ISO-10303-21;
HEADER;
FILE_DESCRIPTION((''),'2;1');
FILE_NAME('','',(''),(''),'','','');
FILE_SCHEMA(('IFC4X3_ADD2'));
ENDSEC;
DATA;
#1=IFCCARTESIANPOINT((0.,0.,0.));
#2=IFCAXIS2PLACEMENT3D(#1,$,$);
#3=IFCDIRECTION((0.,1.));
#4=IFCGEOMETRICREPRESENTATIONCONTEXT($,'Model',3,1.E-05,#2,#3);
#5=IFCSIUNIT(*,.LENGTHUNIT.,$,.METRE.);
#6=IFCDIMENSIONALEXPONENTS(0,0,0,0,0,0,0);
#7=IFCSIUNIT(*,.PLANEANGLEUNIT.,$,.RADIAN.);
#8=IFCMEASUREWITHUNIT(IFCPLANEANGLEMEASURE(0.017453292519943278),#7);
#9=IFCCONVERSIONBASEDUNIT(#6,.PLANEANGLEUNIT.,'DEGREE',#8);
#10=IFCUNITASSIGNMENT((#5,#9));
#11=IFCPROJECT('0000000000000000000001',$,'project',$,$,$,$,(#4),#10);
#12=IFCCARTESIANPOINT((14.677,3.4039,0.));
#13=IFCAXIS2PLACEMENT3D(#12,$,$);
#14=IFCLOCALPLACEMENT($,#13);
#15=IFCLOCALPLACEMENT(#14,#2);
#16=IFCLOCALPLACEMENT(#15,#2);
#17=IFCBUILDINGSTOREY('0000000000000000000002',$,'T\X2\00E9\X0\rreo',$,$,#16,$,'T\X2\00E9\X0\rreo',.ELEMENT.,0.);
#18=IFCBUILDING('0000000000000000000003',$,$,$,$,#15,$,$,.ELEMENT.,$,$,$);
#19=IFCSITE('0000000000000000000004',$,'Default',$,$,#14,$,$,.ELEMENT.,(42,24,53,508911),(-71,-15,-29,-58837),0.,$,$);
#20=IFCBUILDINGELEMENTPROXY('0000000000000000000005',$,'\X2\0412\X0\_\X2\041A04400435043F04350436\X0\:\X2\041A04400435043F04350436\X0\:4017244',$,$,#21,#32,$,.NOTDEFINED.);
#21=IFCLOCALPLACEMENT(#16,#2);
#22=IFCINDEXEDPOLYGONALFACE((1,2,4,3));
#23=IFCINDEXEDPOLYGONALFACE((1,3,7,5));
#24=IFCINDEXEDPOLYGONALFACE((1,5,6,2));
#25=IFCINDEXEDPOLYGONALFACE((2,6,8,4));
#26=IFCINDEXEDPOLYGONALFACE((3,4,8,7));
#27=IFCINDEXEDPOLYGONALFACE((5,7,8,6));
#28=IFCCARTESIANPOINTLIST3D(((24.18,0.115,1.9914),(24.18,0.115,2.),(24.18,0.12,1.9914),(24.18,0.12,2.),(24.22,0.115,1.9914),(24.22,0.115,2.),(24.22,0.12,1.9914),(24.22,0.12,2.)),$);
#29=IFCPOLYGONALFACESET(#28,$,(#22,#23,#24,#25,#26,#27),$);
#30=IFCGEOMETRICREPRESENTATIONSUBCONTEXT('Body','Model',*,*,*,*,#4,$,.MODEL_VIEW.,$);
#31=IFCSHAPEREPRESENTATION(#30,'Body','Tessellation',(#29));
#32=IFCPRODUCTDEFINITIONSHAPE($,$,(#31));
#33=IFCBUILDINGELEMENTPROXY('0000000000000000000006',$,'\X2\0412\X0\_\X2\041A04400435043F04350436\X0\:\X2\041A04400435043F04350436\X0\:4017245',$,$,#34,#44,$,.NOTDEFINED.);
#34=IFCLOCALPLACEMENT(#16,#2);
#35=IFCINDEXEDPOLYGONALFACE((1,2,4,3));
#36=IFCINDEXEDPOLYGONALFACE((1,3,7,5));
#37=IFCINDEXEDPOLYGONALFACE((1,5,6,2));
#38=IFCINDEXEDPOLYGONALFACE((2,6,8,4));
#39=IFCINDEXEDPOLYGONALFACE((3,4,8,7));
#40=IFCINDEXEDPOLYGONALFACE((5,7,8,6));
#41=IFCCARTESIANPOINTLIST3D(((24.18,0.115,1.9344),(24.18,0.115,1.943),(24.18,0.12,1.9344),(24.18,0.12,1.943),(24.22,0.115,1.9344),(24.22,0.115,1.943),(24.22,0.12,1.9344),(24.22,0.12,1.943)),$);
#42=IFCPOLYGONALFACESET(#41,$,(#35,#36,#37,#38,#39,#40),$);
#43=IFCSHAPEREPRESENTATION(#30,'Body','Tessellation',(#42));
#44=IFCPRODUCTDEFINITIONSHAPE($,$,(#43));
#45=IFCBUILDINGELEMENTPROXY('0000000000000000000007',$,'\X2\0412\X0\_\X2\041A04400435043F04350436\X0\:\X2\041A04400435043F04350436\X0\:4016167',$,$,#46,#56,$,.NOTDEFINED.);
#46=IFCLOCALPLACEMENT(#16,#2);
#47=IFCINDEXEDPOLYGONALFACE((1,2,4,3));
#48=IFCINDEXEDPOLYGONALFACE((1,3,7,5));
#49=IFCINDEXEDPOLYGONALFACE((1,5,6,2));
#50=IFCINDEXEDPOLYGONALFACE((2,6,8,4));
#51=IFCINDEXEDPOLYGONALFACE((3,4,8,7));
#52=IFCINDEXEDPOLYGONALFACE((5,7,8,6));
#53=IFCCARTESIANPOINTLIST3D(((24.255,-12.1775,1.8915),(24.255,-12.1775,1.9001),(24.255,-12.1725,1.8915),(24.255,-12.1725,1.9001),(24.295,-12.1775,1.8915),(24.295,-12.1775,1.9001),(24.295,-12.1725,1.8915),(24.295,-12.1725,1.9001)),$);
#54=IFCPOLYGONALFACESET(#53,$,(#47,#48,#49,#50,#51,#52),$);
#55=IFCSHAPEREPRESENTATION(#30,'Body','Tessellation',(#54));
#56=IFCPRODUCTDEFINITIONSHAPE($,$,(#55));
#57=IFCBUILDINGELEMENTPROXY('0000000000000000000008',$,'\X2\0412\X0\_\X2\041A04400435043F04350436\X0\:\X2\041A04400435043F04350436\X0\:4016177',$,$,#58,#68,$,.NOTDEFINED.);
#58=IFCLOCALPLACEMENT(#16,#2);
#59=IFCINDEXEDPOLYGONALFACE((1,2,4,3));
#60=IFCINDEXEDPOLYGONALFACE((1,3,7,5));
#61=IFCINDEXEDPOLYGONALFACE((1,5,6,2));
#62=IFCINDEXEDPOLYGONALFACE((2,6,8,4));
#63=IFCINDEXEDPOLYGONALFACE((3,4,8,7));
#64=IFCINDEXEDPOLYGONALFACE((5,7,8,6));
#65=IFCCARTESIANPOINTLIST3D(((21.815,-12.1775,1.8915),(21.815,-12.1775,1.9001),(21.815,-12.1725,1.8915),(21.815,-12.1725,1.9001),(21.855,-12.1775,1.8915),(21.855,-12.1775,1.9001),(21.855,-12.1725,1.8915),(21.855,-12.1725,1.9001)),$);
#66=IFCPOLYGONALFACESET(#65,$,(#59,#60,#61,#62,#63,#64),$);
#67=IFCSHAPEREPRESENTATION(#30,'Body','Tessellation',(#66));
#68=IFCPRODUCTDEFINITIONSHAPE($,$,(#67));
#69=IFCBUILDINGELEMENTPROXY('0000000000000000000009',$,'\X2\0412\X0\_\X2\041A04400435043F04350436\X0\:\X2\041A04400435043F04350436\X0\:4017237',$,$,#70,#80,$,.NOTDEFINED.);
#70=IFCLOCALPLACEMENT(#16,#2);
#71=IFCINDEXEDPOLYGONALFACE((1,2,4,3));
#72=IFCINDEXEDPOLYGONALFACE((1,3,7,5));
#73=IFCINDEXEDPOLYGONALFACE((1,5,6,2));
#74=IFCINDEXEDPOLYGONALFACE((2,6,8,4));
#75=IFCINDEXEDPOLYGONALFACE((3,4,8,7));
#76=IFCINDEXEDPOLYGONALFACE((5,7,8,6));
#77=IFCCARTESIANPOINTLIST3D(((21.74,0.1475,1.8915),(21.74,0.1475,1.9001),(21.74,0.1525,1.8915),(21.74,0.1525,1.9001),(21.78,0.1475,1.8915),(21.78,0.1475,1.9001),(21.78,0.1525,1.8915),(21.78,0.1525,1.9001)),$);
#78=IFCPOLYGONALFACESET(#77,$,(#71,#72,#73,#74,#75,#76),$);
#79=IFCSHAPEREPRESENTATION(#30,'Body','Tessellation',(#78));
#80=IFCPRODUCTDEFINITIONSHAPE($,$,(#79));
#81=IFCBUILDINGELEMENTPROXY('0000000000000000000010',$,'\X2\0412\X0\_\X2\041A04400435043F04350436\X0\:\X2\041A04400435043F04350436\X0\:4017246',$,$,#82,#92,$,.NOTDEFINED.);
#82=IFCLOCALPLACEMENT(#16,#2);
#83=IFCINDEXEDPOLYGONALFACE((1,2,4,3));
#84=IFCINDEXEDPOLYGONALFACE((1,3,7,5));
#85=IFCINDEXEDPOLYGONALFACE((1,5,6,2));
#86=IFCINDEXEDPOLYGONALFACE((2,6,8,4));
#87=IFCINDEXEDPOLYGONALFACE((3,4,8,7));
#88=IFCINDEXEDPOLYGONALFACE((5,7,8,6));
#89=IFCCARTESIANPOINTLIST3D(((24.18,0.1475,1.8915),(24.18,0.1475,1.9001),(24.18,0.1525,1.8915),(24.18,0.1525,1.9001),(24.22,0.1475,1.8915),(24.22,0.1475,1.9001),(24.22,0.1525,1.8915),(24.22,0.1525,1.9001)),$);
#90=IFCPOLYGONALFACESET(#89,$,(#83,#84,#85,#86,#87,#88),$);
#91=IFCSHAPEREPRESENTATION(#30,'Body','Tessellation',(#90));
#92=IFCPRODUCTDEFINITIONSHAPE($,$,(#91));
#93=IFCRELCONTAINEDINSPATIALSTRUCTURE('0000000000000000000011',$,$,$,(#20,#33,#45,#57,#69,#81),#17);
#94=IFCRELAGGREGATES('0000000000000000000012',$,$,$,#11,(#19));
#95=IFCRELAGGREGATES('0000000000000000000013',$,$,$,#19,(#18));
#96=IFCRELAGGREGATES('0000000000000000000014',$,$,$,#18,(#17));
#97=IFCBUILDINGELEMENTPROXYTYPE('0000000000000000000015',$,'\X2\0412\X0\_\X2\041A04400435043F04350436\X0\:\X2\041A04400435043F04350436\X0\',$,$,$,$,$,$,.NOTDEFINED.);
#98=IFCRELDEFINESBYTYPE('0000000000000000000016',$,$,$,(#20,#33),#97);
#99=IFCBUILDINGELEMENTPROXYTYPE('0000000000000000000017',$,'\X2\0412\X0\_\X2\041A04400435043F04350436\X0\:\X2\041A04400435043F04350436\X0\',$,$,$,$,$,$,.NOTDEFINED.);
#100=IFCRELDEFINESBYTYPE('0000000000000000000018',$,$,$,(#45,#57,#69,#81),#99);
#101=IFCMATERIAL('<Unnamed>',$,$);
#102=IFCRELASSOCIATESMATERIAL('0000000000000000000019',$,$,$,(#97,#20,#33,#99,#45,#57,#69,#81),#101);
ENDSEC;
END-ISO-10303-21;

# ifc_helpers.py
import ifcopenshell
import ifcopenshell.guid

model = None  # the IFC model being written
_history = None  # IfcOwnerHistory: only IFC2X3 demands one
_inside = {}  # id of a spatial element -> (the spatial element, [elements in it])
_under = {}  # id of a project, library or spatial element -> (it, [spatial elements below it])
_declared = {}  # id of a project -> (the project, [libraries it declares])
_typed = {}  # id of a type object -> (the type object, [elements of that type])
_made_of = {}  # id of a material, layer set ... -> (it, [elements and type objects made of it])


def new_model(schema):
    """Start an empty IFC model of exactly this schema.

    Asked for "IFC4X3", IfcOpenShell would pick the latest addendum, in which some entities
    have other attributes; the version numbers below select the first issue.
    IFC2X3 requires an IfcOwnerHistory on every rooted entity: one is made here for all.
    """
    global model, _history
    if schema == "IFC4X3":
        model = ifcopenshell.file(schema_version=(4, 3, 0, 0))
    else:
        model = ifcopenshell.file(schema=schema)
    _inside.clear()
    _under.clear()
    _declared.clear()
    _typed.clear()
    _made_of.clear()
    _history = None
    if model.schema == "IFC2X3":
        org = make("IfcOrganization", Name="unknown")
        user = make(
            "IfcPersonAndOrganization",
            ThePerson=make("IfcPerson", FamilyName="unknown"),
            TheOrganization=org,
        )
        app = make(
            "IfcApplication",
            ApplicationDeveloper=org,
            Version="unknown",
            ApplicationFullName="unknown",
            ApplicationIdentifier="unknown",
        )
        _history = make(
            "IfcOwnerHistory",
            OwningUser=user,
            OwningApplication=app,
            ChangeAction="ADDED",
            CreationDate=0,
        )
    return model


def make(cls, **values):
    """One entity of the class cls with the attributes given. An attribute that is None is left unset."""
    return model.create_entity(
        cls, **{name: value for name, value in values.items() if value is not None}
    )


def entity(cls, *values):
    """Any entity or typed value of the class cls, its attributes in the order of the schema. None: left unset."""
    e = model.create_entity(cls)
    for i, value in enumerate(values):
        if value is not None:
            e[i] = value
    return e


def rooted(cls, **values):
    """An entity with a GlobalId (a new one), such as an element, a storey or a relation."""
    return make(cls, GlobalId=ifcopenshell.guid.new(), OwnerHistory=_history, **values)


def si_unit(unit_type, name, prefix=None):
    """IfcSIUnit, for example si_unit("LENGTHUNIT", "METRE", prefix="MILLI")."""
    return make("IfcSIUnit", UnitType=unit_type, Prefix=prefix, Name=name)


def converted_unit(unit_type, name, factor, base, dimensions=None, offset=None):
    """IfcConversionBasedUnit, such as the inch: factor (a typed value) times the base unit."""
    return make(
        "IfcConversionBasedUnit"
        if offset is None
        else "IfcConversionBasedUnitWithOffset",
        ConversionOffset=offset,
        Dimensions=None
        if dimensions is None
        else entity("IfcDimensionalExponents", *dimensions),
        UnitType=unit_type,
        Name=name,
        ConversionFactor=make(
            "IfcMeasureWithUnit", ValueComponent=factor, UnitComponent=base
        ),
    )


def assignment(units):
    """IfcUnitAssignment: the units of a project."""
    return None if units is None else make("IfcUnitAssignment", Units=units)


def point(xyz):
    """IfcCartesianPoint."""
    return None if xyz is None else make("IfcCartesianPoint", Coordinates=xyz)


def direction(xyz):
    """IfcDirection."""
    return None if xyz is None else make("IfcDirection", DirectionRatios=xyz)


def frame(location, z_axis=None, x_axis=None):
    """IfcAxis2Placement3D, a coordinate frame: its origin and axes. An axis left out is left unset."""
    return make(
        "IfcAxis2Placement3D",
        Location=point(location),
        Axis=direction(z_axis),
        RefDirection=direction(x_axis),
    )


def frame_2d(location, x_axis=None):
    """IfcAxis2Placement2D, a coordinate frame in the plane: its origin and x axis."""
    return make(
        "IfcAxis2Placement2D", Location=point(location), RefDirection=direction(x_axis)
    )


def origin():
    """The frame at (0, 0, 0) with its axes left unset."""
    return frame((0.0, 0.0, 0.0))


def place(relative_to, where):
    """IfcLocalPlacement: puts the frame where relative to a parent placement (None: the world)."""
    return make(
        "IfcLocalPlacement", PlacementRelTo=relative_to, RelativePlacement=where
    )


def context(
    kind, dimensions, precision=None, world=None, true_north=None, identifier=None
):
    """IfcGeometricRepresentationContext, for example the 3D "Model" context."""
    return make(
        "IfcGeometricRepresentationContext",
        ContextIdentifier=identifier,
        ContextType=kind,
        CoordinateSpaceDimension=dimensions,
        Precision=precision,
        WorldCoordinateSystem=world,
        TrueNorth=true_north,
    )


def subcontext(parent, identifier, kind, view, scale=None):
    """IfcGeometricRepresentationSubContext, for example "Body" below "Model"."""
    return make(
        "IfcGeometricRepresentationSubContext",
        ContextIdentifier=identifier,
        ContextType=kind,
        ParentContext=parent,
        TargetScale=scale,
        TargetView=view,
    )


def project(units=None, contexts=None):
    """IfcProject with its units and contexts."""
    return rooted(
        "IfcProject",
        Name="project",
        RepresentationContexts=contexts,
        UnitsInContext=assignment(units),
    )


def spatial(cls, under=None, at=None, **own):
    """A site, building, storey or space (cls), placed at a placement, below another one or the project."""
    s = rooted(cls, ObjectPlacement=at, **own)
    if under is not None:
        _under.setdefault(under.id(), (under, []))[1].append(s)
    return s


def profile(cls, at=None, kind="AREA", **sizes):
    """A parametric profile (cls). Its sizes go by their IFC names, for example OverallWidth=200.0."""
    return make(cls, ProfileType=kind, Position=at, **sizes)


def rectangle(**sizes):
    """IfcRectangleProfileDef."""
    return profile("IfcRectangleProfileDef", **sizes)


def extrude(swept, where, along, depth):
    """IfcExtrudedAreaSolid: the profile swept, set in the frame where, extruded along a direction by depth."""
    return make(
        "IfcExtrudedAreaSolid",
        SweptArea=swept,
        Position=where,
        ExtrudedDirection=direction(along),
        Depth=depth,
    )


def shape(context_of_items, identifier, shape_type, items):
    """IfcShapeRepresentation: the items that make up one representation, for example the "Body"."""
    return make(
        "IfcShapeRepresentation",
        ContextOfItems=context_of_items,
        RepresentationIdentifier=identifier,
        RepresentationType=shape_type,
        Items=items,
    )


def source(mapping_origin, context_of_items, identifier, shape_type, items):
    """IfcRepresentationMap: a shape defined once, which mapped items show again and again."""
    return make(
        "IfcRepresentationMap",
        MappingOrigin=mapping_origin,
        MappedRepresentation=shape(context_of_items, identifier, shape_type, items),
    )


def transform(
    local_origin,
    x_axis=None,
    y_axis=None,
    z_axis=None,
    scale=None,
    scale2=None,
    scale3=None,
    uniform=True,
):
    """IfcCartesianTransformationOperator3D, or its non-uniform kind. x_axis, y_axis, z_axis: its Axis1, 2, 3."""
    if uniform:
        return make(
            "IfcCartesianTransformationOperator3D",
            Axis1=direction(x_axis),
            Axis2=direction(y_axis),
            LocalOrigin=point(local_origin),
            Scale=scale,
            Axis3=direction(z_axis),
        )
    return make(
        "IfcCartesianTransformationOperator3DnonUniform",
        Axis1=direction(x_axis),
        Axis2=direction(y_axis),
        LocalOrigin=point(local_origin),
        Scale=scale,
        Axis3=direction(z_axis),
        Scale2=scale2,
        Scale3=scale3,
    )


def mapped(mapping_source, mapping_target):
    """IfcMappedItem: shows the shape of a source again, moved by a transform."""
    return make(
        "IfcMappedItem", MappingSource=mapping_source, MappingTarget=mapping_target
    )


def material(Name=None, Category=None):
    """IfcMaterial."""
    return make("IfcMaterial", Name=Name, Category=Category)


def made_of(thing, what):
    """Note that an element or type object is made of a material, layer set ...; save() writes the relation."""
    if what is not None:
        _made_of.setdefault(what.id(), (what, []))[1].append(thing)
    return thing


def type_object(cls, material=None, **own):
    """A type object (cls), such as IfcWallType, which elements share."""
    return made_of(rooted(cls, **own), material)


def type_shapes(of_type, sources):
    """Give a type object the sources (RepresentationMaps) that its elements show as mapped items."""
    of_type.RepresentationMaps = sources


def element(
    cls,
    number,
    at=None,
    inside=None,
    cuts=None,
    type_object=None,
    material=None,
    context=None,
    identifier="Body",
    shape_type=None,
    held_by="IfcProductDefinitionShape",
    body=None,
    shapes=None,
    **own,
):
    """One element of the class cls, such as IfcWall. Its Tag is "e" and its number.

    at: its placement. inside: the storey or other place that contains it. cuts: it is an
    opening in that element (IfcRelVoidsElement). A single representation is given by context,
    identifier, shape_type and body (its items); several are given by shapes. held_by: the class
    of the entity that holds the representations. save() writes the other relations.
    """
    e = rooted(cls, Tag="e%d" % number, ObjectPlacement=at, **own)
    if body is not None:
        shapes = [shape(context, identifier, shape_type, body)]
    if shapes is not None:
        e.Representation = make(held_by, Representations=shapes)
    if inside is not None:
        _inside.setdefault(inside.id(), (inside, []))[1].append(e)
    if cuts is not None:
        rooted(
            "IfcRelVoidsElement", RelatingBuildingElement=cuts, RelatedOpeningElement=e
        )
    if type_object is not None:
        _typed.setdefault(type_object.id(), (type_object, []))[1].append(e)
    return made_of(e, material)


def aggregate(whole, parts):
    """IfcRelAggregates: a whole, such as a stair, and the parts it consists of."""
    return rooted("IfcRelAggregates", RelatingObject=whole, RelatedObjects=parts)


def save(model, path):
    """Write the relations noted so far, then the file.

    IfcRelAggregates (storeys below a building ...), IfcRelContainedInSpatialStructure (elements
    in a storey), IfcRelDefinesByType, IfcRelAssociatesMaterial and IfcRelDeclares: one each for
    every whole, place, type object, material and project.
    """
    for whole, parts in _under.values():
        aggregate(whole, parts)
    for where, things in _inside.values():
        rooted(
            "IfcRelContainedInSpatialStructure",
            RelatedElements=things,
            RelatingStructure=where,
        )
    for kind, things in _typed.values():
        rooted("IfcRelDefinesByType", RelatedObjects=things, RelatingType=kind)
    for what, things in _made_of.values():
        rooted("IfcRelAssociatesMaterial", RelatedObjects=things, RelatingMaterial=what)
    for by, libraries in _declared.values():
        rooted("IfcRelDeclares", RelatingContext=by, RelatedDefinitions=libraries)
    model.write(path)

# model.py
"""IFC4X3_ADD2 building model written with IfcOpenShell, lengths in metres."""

from ifc_helpers import new_model, entity, si_unit, converted_unit, direction, frame, frame_2d, origin, place, context, subcontext, project, spatial, rectangle, extrude, source, transform, mapped, material, type_object, type_shapes, element, save


model = new_model("IFC4X3_ADD2")

# Units and contexts
model_context = context("Model", 3, precision=1e-05, world=origin(), true_north=direction((0.0, 1.0)))
body_context = subcontext(model_context, "Body", "Model", "MODEL_VIEW")
ifc_project = project(units=[si_unit("LENGTHUNIT", "METRE"), converted_unit("PLANEANGLEUNIT", "DEGREE", entity("IfcPlaneAngleMeasure", 0.017453292519943278), si_unit("PLANEANGLEUNIT", "RADIAN"), dimensions=[0, 0, 0, 0, 0, 0, 0])], contexts=[model_context])

# Site, building, storey
site_placement = place(None, frame((14.677, 3.4039, 0.0)))
site = spatial("IfcSite", under=ifc_project, at=site_placement, Name="Default", CompositionType="ELEMENT", RefLatitude=(42, 24, 53, 508911), RefLongitude=(-71, -15, -29, -58837), RefElevation=0.0)
building_placement = place(site_placement, origin())
building = spatial("IfcBuilding", under=site, at=building_placement, CompositionType="ELEMENT")
storey_placement = place(building_placement, origin())
storey = spatial("IfcBuildingStorey", under=building, at=storey_placement, Name="Térreo", LongName="Térreo", CompositionType="ELEMENT", Elevation=0.0)

# Building element proxies
ifc_material_1 = material(Name="<Unnamed>")
building_element_proxy_type_1 = type_object("IfcBuildingElementProxyType", Name="В_Крепеж:Крепеж", PredefinedType="NOTDEFINED", material=ifc_material_1)
shared_shape_1 = source(origin(), body_context, "Body", "SweptSolid", [
    extrude(rectangle(XDim=0.005, YDim=0.04, at=frame_2d((0.0, 0.0), x_axis=(1.0, 0.0))), frame((0.0, 0.0, -0.0043), z_axis=(0.0, 0.0, 1.0), x_axis=(0.0, 1.0, 0.0)), (0.0, 0.0, 1.0), 0.0086),
])
type_shapes(building_element_proxy_type_1, [shared_shape_1])
for number, where, name in (
    (1, (24.2, 0.1175, 1.9957), "В_Крепеж:Крепеж:4017244"),
    (2, (24.2, 0.1175, 1.9387), "В_Крепеж:Крепеж:4017245"),
):
    element("IfcBuildingElementProxy", number, at=place(storey_placement, frame(where)), inside=storey, type_object=building_element_proxy_type_1, material=ifc_material_1, Name=name, PredefinedType="NOTDEFINED", context=body_context, shape_type="MappedRepresentation", body=[
        mapped(shared_shape_1, transform((0.0, 0.0, 0.0), scale=1.0)),
    ])
building_element_proxy_type_2 = type_object("IfcBuildingElementProxyType", Name="В_Крепеж:Крепеж", PredefinedType="NOTDEFINED", material=ifc_material_1)
shared_shape_2 = source(origin(), body_context, "Body", "SweptSolid", [
    extrude(rectangle(XDim=0.04, YDim=0.005, at=frame_2d((0.0, 0.0), x_axis=(1.0, 0.0))), frame((0.0, 0.0, -0.0043), z_axis=(0.0, 0.0, 1.0), x_axis=(-1.0, 0.0, 0.0)), (0.0, 0.0, 1.0), 0.0086),
])
type_shapes(building_element_proxy_type_2, [shared_shape_2])
for number, where, z_axis, x_axis, name in (
    (3, (24.275, -12.175, 1.8958), (0.0, 0.0, 1.0), (-1.0, 0.0, 0.0), "В_Крепеж:Крепеж:4016167"),
    (4, (21.835, -12.175, 1.8958), (0.0, 0.0, 1.0), (-1.0, 0.0, 0.0), "В_Крепеж:Крепеж:4016177"),
):
    element("IfcBuildingElementProxy", number, at=place(storey_placement, frame(where, z_axis=z_axis, x_axis=x_axis)), inside=storey, type_object=building_element_proxy_type_2, material=ifc_material_1, Name=name, PredefinedType="NOTDEFINED", context=body_context, shape_type="MappedRepresentation", body=[
        mapped(shared_shape_2, transform((0.0, 0.0, 0.0), scale=1.0)),
    ])
for number, where, name in (
    (5, (21.76, 0.15, 1.8958), "В_Крепеж:Крепеж:4017237"),
    (6, (24.2, 0.15, 1.8958), "В_Крепеж:Крепеж:4017246"),
):
    element("IfcBuildingElementProxy", number, at=place(storey_placement, frame(where)), inside=storey, type_object=building_element_proxy_type_2, material=ifc_material_1, Name=name, PredefinedType="NOTDEFINED", context=body_context, shape_type="MappedRepresentation", body=[
        mapped(shared_shape_2, transform((0.0, 0.0, 0.0), scale=1.0)),
    ])

save(model, "model.ifc")
